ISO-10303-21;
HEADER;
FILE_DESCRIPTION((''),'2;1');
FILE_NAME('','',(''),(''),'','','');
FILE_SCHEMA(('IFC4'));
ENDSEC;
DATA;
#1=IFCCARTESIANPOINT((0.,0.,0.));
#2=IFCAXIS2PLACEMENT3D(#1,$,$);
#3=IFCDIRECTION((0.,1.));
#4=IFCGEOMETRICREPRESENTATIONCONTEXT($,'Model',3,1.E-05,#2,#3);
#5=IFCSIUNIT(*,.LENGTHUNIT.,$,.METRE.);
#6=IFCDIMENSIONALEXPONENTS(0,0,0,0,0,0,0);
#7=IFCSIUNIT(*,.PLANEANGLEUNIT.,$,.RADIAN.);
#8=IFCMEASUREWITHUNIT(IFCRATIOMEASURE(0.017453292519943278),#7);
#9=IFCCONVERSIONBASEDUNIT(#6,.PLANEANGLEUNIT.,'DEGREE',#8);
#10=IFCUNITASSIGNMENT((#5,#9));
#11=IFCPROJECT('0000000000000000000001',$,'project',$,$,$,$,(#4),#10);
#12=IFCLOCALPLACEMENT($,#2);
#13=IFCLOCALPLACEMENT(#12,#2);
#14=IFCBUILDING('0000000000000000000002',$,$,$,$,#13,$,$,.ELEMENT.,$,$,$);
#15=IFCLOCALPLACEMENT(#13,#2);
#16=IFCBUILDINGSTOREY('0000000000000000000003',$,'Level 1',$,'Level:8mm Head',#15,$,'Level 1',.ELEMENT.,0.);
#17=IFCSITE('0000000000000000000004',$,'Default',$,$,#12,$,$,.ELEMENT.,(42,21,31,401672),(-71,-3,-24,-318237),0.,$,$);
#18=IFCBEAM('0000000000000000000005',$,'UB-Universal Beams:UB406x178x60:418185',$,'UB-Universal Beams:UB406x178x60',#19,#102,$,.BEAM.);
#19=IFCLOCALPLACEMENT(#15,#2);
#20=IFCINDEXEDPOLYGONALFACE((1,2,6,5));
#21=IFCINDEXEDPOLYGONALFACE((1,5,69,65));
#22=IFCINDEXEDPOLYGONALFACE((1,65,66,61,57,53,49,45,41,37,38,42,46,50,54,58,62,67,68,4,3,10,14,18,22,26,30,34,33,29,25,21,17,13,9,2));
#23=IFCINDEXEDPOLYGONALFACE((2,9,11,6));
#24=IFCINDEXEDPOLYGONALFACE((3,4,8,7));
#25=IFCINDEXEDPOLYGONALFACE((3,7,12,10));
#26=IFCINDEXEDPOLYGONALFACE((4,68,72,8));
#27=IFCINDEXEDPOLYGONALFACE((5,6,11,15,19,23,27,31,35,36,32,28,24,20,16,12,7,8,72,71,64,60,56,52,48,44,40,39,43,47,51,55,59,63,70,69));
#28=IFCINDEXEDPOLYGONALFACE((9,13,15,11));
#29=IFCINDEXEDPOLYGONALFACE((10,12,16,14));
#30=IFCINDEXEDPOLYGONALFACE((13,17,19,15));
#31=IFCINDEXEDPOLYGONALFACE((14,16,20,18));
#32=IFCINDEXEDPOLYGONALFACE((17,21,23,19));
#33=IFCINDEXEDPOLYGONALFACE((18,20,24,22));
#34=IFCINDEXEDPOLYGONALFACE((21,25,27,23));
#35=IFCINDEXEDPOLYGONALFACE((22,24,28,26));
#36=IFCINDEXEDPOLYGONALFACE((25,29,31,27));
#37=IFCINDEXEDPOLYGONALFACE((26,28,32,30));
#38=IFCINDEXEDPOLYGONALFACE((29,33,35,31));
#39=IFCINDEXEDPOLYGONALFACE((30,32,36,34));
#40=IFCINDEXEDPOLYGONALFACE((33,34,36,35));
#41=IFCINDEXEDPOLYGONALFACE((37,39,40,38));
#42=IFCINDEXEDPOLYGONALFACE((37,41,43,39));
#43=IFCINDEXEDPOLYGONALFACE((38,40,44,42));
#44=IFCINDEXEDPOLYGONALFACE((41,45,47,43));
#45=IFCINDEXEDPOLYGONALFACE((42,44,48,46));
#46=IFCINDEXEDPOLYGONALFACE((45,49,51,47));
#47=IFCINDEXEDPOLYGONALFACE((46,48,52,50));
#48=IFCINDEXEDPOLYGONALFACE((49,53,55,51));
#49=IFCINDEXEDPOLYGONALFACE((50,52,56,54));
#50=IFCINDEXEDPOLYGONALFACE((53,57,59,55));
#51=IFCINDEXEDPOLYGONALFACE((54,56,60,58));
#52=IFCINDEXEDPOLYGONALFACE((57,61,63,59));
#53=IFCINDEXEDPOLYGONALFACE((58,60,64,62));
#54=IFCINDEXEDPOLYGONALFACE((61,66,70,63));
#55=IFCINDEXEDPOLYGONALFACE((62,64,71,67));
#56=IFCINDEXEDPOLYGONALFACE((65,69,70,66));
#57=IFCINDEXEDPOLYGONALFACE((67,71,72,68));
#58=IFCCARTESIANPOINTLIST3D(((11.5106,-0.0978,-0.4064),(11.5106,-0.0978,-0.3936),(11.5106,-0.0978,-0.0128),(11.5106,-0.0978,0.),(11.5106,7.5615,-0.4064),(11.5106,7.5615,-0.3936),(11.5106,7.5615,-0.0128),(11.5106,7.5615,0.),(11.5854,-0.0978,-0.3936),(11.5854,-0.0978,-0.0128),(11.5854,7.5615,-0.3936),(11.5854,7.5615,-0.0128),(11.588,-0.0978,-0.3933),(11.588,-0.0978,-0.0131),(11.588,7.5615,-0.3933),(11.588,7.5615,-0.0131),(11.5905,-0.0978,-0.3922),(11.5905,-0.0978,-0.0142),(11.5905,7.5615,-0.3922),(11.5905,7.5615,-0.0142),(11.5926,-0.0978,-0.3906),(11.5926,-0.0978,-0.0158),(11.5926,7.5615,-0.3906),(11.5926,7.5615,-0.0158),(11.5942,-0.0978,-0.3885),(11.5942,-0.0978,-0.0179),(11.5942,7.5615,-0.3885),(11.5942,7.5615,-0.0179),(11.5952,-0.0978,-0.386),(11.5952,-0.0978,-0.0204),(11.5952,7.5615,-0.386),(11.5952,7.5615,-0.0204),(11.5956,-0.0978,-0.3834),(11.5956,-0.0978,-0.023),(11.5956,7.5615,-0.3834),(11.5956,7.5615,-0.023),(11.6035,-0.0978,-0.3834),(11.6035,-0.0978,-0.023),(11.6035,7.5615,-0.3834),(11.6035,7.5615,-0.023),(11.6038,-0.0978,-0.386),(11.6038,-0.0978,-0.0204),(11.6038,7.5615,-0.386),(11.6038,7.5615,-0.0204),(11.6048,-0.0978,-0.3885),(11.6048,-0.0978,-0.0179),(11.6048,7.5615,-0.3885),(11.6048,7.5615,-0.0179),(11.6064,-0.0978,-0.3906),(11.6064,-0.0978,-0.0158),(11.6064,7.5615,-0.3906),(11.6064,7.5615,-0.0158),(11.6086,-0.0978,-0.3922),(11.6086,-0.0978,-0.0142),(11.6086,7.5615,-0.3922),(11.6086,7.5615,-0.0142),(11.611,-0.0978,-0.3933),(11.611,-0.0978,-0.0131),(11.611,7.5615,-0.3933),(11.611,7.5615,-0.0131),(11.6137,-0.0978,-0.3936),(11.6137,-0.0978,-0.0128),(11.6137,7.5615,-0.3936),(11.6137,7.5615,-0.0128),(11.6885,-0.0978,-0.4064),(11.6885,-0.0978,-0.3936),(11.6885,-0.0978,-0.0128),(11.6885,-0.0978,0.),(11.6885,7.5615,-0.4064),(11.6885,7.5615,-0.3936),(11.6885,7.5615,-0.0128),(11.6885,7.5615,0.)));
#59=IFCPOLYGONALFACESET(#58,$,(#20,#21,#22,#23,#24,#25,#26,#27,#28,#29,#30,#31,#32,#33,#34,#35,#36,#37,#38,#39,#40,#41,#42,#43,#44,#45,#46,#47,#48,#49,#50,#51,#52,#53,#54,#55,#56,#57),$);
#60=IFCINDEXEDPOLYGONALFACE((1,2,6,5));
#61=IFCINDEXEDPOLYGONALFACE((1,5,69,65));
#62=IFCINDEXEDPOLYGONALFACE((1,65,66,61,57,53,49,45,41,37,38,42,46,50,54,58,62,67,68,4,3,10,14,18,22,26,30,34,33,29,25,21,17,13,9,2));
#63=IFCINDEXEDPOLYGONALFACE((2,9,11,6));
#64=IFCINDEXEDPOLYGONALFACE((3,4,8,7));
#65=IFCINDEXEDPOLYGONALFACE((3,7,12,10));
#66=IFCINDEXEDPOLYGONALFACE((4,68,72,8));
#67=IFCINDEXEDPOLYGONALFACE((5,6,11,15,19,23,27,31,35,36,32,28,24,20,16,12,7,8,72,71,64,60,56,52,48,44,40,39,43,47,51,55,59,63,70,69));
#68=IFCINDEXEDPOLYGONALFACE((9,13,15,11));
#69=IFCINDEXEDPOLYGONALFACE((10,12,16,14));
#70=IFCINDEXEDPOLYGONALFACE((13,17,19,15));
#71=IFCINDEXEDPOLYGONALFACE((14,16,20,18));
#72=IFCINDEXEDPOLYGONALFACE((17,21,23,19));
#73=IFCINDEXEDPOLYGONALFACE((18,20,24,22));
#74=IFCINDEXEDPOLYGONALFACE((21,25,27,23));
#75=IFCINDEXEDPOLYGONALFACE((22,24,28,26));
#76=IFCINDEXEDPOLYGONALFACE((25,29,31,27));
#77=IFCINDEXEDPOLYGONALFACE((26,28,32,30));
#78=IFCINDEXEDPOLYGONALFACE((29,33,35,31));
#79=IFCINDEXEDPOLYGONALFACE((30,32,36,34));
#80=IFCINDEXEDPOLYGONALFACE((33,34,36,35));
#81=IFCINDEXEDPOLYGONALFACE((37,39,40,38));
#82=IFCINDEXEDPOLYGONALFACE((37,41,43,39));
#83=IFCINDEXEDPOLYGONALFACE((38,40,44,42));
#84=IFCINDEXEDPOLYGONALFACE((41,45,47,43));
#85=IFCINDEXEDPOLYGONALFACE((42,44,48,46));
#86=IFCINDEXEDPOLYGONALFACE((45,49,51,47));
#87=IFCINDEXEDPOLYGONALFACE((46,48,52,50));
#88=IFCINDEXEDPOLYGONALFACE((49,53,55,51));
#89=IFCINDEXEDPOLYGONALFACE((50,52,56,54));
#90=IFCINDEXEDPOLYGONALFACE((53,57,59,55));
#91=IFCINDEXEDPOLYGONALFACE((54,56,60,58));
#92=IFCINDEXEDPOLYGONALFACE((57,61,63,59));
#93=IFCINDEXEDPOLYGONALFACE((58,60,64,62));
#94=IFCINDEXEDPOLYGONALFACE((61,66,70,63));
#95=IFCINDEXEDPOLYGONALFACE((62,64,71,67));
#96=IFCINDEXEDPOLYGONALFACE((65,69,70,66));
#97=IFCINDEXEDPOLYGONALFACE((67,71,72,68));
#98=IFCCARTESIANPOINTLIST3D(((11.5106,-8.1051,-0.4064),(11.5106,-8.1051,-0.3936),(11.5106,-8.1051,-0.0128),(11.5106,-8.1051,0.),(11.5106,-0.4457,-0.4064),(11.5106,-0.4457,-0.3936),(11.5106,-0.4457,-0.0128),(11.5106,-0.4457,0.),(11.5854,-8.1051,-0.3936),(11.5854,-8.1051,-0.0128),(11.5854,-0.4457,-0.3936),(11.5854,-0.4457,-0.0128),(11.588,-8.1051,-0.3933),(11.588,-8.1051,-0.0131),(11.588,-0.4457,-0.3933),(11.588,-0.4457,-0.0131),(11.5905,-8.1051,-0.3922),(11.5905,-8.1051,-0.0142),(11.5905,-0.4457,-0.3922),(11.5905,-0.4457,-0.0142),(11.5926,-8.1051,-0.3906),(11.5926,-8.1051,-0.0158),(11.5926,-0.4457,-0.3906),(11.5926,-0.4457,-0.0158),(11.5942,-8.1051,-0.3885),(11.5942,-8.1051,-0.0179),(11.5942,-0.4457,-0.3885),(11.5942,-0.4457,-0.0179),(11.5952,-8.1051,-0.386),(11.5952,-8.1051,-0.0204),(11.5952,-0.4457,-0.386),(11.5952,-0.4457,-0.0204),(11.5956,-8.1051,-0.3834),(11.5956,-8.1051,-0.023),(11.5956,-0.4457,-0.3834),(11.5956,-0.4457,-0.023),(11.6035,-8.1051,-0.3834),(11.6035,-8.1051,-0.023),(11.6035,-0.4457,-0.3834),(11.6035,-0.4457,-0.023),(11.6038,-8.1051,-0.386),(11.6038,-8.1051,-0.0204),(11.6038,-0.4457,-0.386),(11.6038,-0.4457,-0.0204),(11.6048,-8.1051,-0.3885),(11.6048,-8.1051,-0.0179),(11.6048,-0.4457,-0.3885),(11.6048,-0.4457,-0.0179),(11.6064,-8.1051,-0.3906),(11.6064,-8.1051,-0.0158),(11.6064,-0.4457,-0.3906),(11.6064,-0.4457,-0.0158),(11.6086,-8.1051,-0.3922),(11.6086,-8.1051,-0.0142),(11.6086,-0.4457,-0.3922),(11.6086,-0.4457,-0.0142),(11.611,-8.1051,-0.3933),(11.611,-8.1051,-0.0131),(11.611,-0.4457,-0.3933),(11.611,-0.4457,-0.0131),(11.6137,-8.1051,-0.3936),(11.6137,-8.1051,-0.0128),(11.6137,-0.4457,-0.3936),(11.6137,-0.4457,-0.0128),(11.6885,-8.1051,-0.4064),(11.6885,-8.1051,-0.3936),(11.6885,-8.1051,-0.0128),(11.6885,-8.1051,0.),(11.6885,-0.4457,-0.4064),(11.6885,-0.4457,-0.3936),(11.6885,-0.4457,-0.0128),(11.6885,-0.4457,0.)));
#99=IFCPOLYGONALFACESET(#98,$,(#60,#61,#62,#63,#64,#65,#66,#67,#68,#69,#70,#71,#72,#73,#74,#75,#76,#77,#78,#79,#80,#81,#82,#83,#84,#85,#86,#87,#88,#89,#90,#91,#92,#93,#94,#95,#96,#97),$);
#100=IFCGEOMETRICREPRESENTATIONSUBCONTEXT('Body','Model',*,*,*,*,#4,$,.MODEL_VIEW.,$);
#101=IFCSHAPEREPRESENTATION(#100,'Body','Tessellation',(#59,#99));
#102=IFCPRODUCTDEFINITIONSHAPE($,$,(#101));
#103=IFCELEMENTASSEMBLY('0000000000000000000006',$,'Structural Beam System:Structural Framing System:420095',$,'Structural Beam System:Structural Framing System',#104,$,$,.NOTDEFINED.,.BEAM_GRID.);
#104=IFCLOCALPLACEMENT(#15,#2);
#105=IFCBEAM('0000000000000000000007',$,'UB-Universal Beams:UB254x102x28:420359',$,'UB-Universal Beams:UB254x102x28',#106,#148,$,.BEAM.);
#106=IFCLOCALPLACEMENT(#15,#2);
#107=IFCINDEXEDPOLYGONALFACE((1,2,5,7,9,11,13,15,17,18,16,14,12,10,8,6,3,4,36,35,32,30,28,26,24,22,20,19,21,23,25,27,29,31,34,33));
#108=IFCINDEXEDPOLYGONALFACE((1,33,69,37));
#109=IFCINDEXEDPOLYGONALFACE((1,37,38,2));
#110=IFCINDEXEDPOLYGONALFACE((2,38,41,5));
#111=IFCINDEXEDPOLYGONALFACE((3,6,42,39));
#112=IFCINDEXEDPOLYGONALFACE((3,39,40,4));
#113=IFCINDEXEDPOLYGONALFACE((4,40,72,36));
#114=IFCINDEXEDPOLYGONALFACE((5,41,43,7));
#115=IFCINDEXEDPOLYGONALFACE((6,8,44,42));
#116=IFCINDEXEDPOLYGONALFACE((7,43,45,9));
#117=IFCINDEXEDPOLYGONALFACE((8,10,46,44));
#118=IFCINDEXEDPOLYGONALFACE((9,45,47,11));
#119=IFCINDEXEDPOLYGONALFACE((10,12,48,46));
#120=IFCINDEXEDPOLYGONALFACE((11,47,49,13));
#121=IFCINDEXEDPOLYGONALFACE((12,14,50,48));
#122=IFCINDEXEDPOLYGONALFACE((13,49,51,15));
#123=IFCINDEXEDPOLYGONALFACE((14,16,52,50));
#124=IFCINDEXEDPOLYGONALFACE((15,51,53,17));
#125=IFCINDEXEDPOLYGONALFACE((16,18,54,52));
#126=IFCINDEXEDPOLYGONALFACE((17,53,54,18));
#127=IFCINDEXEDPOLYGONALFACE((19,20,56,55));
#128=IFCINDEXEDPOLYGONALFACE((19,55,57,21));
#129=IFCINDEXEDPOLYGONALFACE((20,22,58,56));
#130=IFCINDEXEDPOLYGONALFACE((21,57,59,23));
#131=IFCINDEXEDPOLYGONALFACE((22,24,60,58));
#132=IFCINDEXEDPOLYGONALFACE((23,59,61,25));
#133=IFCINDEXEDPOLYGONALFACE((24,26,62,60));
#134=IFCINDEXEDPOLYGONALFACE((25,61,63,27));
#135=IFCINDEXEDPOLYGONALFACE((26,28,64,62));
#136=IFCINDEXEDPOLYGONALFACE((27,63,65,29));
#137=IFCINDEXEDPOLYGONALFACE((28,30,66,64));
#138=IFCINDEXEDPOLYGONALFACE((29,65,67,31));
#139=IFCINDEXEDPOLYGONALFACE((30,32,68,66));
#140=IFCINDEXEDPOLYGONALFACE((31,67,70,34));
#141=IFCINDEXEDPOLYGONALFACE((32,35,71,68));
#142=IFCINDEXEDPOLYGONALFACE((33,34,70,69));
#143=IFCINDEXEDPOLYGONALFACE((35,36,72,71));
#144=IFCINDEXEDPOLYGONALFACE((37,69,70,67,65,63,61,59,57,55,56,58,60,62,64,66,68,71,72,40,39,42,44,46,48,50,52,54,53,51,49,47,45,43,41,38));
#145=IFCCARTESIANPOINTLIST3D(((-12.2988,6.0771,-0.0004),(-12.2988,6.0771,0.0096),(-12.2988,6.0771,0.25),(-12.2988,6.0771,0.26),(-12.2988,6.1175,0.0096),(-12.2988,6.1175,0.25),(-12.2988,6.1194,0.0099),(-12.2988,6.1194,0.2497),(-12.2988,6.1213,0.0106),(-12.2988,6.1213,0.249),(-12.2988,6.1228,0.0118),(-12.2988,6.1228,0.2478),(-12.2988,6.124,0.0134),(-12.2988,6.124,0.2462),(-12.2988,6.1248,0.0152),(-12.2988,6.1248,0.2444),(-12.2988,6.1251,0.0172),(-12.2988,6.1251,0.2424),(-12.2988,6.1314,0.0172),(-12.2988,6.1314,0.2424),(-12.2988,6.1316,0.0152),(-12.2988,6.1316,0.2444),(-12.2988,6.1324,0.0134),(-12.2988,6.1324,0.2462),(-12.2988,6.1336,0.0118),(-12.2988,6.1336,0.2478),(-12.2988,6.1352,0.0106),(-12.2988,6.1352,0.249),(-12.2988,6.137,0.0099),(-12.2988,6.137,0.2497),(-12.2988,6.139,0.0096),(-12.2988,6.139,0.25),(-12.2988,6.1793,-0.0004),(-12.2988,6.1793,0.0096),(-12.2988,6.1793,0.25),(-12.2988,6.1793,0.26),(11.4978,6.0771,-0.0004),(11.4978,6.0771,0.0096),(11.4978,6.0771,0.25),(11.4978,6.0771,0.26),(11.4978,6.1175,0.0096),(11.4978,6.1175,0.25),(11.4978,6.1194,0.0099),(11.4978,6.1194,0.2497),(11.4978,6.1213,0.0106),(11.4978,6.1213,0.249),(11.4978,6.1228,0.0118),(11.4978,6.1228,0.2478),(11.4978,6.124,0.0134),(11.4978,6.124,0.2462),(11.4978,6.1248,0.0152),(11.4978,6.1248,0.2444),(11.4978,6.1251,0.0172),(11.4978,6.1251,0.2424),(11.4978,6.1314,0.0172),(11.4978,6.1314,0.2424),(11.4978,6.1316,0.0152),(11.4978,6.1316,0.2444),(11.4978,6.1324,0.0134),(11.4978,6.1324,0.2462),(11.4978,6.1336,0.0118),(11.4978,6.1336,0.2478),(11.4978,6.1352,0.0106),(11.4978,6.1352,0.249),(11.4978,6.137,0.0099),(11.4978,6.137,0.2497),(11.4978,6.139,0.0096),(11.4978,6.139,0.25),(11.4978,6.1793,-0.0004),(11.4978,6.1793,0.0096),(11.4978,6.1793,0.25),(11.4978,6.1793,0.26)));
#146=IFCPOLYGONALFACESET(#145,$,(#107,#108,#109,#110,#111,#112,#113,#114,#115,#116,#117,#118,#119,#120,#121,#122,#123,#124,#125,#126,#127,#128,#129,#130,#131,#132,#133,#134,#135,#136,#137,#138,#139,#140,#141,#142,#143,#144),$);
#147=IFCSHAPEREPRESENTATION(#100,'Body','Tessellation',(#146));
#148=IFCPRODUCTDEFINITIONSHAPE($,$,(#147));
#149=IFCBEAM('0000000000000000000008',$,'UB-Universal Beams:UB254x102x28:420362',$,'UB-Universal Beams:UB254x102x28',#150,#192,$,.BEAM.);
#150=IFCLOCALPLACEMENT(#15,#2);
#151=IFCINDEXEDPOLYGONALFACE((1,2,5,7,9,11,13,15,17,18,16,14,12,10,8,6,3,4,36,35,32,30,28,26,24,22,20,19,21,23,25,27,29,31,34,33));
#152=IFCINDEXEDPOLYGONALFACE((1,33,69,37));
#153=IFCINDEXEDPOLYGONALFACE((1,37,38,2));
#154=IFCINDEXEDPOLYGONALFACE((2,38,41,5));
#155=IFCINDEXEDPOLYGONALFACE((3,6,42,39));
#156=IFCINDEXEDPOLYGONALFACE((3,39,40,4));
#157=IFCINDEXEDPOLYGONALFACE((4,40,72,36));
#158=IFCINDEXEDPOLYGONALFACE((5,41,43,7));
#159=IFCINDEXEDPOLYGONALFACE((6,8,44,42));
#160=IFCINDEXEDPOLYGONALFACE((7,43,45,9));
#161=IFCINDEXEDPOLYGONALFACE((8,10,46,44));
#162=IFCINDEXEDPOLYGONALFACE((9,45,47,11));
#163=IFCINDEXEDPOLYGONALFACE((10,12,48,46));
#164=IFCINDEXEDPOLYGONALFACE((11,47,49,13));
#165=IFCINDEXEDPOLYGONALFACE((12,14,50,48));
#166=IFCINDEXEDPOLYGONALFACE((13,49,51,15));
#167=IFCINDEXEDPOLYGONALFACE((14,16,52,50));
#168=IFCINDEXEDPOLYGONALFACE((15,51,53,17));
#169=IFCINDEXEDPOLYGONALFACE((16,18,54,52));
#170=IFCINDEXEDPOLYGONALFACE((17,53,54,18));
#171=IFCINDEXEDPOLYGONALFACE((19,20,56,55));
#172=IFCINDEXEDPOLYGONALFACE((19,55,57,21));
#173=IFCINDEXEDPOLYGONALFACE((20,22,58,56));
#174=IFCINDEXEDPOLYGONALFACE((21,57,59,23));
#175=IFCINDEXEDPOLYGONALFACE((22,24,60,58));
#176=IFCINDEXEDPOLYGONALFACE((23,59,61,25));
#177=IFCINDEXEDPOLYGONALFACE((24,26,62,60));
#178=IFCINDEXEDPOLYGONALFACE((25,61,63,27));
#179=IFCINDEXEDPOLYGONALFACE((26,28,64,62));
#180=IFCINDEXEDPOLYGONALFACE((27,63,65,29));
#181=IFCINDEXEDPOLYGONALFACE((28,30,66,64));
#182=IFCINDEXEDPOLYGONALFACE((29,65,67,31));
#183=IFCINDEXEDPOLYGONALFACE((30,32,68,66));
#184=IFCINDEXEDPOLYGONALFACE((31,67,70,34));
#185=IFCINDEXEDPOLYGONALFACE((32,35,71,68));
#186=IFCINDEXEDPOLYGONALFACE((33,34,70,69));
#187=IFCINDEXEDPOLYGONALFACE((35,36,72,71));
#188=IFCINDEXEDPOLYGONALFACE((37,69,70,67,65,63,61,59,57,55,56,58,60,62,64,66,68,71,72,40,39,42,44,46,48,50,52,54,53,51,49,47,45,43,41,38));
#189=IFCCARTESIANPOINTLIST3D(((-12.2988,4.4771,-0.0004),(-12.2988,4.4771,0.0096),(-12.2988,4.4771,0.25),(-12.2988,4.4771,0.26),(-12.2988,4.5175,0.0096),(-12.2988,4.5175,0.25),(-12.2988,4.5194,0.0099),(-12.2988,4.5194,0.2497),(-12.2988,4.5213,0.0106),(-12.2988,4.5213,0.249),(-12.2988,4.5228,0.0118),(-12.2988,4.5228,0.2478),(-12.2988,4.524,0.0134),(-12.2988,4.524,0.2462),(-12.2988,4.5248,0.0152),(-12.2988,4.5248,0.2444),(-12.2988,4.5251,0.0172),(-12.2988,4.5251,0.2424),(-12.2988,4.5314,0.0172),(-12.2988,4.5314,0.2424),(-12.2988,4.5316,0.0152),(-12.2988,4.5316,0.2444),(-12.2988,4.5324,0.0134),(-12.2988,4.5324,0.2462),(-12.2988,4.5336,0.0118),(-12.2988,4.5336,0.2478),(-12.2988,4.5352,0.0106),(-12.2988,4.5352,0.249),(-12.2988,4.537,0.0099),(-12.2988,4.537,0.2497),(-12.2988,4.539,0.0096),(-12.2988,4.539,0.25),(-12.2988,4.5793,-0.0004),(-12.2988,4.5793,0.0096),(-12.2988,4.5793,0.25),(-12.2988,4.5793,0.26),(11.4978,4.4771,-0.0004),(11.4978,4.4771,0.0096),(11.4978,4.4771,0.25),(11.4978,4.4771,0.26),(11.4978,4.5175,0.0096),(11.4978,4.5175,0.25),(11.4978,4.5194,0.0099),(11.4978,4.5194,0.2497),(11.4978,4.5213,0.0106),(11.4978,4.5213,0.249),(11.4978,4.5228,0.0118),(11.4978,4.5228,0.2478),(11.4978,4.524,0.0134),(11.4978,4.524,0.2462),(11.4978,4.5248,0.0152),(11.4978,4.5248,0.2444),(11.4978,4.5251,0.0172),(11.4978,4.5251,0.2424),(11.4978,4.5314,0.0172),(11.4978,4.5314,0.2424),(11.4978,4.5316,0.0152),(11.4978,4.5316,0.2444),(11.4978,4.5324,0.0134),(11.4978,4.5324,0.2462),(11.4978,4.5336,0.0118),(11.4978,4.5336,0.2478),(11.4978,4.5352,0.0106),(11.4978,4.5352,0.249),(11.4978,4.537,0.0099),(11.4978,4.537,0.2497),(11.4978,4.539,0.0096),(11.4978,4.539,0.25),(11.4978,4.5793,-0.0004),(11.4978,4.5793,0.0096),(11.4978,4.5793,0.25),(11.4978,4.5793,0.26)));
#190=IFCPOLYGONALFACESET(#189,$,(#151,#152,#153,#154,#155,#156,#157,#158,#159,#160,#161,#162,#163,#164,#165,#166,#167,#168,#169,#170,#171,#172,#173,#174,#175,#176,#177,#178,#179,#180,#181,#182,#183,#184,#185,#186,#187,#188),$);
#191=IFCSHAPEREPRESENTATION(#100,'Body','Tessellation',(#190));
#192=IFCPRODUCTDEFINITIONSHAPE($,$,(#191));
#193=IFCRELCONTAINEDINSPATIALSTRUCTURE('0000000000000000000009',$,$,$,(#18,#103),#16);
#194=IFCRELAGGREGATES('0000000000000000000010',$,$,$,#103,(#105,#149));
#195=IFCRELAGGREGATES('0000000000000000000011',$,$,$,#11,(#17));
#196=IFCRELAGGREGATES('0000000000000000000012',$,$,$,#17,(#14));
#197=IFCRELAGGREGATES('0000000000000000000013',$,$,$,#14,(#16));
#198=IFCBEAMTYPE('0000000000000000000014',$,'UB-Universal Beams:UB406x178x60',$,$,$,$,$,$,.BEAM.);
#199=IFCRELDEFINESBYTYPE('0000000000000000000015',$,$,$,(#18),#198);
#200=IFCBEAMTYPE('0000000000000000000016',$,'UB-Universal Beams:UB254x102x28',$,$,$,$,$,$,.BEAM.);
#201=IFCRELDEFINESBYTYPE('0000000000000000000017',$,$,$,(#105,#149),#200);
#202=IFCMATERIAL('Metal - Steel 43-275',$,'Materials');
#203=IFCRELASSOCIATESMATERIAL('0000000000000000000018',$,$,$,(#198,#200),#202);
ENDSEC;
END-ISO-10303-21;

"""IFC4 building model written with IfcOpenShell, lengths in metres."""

from ifc_helpers import new_model, entity, si_unit, converted_unit, direction, frame, frame_2d, origin, place, context, subcontext, project, spatial, i_section, extrude, source, transform, mapped, material, material_profile, profile_set, type_object, type_shapes, element, aggregate, save


model = new_model("IFC4")

# Units and contexts
model_context = context("Model", 3, precision=1e-05, world=origin(), true_north=direction((0.0, 1.0)))
body_context = subcontext(model_context, "Body", "Model", "MODEL_VIEW")
ifc_project = project(units=[si_unit("LENGTHUNIT", "METRE"), converted_unit("PLANEANGLEUNIT", "DEGREE", entity("IfcRatioMeasure", 0.017453292519943278), si_unit("PLANEANGLEUNIT", "RADIAN"), dimensions=[0, 0, 0, 0, 0, 0, 0])], contexts=[model_context])

# Site, building, storey
site_placement = place(None, origin())
site = spatial("IfcSite", under=ifc_project, at=site_placement, Name="Default", CompositionType="ELEMENT", RefLatitude=(42, 21, 31, 401672), RefLongitude=(-71, -3, -24, -318237), RefElevation=0.0)
building_placement = place(site_placement, origin())
building = spatial("IfcBuilding", under=site, at=building_placement, CompositionType="ELEMENT")
storey_placement = place(building_placement, origin())
storey = spatial("IfcBuildingStorey", under=building, at=storey_placement, Name="Level 1", ObjectType="Level:8mm Head", LongName="Level 1", CompositionType="ELEMENT", Elevation=0.0)

# Beam
ifc_material_1 = material(Name="Metal - Steel 43-275", Category="Materials")
ifc_material_profile_1 = material_profile(ifc_material_1, i_section(OverallWidth=0.1779, OverallDepth=0.4064, WebThickness=0.0079, FlangeThickness=0.0128, FilletRadius=0.0102, at=frame_2d((0.0, 0.0), x_axis=(0.0, 1.0))), Name="UB406x178x60")
ifc_profile_set_1 = profile_set([ifc_material_profile_1], Name="UB406x178x60")
beam_type_1 = type_object("IfcBeamType", Name="UB-Universal Beams:UB406x178x60", PredefinedType="BEAM", material=ifc_profile_set_1)
shared_shape_1 = source(origin(), body_context, "Body", "SweptSolid", [
    extrude(i_section(OverallWidth=0.1779, OverallDepth=0.4064, WebThickness=0.0079, FlangeThickness=0.0128, FilletRadius=0.0102, at=frame_2d((0.0, 0.0), x_axis=(1.0, 0.0))), frame((11.5995, -0.0978, -0.2032), z_axis=(0.0, 1.0, 0.0), x_axis=(-1.0, 0.0, 0.0)), (0.0, 0.0, 1.0), 7.6594),
    extrude(i_section(OverallWidth=0.1779, OverallDepth=0.4064, WebThickness=0.0079, FlangeThickness=0.0128, FilletRadius=0.0102, at=frame_2d((0.0, 0.0), x_axis=(1.0, 0.0))), frame((11.5995, -8.1051, -0.2032), z_axis=(0.0, 1.0, 0.0), x_axis=(-1.0, 0.0, 0.0)), (0.0, 0.0, 1.0), 7.6594),
])
type_shapes(beam_type_1, [shared_shape_1])
beam_1_placement = place(storey_placement, origin())
element("IfcBeam", 1, at=beam_1_placement, inside=storey, type_object=beam_type_1, Name="UB-Universal Beams:UB406x178x60:418185", ObjectType="UB-Universal Beams:UB406x178x60", PredefinedType="BEAM", context=body_context, shape_type="MappedRepresentation", body=[
    mapped(shared_shape_1, transform((0.0, 0.0, 0.0), scale=1.0)),
])

# Element assembly, beams
assembly_placement = place(storey_placement, origin())
assembly = element("IfcElementAssembly", 2, at=assembly_placement, inside=storey, Name="Structural Beam System:Structural Framing System:420095", ObjectType="Structural Beam System:Structural Framing System", AssemblyPlace="NOTDEFINED", PredefinedType="BEAM_GRID")
ifc_material_profile_2 = material_profile(ifc_material_1, i_section(OverallWidth=0.1022, OverallDepth=0.2604, WebThickness=0.0063, FlangeThickness=0.01, FilletRadius=0.0076, at=frame_2d((0.0, 0.0), x_axis=(0.0, 1.0))), Name="UB254x102x28")
ifc_profile_set_2 = profile_set([ifc_material_profile_2], Name="UB254x102x28")
beam_type_2 = type_object("IfcBeamType", Name="UB-Universal Beams:UB254x102x28", PredefinedType="BEAM", material=ifc_profile_set_2)
shared_shape_2 = source(origin(), body_context, "Body", "SweptSolid", [
    extrude(i_section(OverallWidth=0.1022, OverallDepth=0.2604, WebThickness=0.0063, FlangeThickness=0.01, FilletRadius=0.0076, at=frame_2d((0.0, 0.0), x_axis=(0.0, 1.0))), frame((-11.8983, 0.0, 0.0), z_axis=(1.0, 0.0, 0.0), x_axis=(0.0, 0.0, -1.0)), (0.0, 0.0, 1.0), 23.7966),
])
type_shapes(beam_type_2, [shared_shape_2])
beam_2_placement = place(assembly_placement, frame((-0.4005, 6.1282, 0.1298)))
beam_2 = element("IfcBeam", 3, at=beam_2_placement, type_object=beam_type_2, Name="UB-Universal Beams:UB254x102x28:420359", ObjectType="UB-Universal Beams:UB254x102x28", PredefinedType="BEAM", context=body_context, shape_type="MappedRepresentation", body=[
    mapped(shared_shape_2, transform((0.0, 0.0, 0.0), scale=1.0)),
])
beam_3_placement = place(assembly_placement, frame((-0.4005, 4.5282, 0.1298)))
beam_3 = element("IfcBeam", 4, at=beam_3_placement, type_object=beam_type_2, Name="UB-Universal Beams:UB254x102x28:420362", ObjectType="UB-Universal Beams:UB254x102x28", PredefinedType="BEAM", context=body_context, shape_type="MappedRepresentation", body=[
    mapped(shared_shape_2, transform((0.0, 0.0, 0.0), scale=1.0)),
])
aggregate(assembly, [beam_2, beam_3])

save(model, "model.ifc")
